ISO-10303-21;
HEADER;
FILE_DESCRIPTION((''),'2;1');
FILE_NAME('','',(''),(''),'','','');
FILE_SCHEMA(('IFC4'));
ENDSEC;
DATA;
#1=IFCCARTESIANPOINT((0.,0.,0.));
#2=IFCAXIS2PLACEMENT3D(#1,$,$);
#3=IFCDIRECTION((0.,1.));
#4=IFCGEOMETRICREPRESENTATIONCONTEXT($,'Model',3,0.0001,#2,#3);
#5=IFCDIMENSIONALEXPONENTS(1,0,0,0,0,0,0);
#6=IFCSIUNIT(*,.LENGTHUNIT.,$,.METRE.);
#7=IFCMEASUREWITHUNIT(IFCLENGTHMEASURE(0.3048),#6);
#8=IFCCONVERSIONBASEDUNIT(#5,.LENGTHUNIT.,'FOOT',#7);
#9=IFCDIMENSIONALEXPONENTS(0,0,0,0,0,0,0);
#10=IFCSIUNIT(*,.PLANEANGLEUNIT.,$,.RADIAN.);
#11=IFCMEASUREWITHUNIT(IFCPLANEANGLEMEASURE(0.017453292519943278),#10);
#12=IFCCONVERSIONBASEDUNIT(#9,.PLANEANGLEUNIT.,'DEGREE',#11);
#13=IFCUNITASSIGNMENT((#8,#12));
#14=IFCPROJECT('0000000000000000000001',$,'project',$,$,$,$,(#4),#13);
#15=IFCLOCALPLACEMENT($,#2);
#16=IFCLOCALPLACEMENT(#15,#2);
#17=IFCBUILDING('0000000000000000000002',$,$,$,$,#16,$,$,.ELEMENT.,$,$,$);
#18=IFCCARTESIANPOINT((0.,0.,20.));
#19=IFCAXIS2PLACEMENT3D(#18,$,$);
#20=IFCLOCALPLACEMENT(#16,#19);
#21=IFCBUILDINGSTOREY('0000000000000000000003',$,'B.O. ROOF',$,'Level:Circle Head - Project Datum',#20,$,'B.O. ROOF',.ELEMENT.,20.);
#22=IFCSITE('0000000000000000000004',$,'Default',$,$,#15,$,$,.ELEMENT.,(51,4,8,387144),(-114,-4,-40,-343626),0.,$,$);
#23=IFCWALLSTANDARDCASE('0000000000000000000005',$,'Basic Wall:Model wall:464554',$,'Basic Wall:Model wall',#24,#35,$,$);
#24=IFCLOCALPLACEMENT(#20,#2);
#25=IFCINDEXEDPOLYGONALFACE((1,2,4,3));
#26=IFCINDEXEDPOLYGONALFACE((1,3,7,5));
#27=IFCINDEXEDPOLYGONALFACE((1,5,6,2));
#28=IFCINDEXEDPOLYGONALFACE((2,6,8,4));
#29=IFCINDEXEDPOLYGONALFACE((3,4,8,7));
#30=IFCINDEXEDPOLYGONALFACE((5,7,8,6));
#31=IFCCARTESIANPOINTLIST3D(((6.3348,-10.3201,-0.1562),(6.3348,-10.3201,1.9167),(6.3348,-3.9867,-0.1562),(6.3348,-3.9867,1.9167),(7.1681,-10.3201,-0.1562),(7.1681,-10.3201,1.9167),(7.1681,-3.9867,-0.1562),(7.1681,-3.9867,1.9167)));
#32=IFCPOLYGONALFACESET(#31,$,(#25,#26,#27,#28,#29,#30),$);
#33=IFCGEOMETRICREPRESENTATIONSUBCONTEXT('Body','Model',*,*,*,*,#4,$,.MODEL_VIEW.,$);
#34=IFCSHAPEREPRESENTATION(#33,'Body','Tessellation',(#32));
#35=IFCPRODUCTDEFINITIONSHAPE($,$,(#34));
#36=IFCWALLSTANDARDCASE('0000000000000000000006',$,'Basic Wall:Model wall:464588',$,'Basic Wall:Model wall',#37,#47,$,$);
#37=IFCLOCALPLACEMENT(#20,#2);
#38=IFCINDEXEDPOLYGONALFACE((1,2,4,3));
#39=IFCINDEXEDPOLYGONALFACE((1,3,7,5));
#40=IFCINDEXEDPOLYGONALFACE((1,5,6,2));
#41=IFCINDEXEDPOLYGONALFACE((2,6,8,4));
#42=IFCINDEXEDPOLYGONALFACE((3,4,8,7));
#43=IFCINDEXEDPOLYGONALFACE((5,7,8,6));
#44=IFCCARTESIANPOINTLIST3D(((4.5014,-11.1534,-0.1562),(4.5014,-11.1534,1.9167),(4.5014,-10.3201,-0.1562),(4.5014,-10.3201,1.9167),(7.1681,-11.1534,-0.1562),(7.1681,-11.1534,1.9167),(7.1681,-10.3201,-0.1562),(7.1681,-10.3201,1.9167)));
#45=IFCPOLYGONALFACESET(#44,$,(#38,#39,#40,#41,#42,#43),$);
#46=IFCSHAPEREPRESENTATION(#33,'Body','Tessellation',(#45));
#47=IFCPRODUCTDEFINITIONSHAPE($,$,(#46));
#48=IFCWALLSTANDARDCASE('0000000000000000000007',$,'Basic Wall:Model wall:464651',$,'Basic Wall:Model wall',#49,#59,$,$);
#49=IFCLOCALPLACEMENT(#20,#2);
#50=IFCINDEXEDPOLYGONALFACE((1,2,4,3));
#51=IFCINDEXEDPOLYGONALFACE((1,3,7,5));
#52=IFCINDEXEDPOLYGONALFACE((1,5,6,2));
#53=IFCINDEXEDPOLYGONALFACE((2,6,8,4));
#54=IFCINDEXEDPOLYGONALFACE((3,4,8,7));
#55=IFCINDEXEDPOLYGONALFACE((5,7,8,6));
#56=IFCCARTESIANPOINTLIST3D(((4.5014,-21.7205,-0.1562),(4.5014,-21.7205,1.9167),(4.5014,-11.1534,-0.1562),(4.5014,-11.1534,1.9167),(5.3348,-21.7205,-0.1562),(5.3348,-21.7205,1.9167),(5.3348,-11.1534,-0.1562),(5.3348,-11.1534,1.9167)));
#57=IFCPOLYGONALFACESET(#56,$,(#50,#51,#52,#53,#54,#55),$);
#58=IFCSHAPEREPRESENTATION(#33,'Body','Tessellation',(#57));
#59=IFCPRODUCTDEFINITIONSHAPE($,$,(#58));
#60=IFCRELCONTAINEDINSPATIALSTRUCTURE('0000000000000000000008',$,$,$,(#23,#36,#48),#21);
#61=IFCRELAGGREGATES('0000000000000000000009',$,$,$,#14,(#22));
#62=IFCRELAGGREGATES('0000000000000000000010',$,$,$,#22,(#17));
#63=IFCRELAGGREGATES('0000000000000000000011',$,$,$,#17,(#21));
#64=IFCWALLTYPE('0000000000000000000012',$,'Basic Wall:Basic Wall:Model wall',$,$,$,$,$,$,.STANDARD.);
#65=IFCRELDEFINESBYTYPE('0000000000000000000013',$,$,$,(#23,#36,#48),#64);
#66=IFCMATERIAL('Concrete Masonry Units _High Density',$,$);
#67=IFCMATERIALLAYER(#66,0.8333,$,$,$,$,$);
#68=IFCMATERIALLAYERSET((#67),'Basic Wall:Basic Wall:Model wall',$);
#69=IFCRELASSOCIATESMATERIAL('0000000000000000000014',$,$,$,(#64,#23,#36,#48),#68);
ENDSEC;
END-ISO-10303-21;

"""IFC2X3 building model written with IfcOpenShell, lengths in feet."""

from ifc_helpers import new_model, entity, si_unit, converted_unit, direction, frame, frame_2d, origin, place, context, subcontext, project, spatial, rectangle, extrude, material, layer, layer_set, layer_usage, type_object, element, save


model = new_model("IFC2X3")

# Units and contexts
model_context = context("Model", 3, precision=0.0001, world=origin(), true_north=direction((0.0, 1.0)))
body_context = subcontext(model_context, "Body", "Model", "MODEL_VIEW")
ifc_project = project(units=[converted_unit("LENGTHUNIT", "FOOT", entity("IfcLengthMeasure", 0.3048), si_unit("LENGTHUNIT", "METRE"), dimensions=[1, 0, 0, 0, 0, 0, 0]), converted_unit("PLANEANGLEUNIT", "DEGREE", entity("IfcPlaneAngleMeasure", 0.017453292519943278), si_unit("PLANEANGLEUNIT", "RADIAN"), dimensions=[0, 0, 0, 0, 0, 0, 0])], contexts=[model_context])

# Site, building, storey
site_placement = place(None, origin())
site = spatial("IfcSite", under=ifc_project, at=site_placement, Name="Default", CompositionType="ELEMENT", RefLatitude=(51, 4, 8, 387144), RefLongitude=(-114, -4, -40, -343626), RefElevation=0.0)
building_placement = place(site_placement, origin())
building = spatial("IfcBuilding", under=site, at=building_placement, CompositionType="ELEMENT")
storey_placement = place(building_placement, frame((0.0, 0.0, 20.0)))
storey = spatial("IfcBuildingStorey", under=building, at=storey_placement, Name="B.O. ROOF", ObjectType="Level:Circle Head - Project Datum", LongName="B.O. ROOF", CompositionType="ELEMENT", Elevation=20.0)

# Walls
ifc_material_1 = material(Name="Concrete Masonry Units _High Density")
ifc_layer = layer(ifc_material_1, 0.8333)
ifc_layer_set = layer_set([ifc_layer], Name="Basic Wall:Basic Wall:Model wall")
wall_type = type_object("IfcWallType", Name="Basic Wall:Basic Wall:Model wall", PredefinedType="STANDARD", material=ifc_layer_set)
ifc_layer_usage_1 = layer_usage(ifc_layer_set, "AXIS2", "NEGATIVE", 0.4167)
wall_1_placement = place(storey_placement, frame((6.7514, -3.9867, -0.1562), z_axis=(0.0, 0.0, 1.0), x_axis=(0.0, -1.0, 0.0)))
element("IfcWallStandardCase", 1, at=wall_1_placement, inside=storey, type_object=wall_type, material=ifc_layer_usage_1, Name="Basic Wall:Model wall:464554", ObjectType="Basic Wall:Model wall", context=body_context, shape_type="SweptSolid", body=[
    extrude(rectangle(XDim=6.3333, YDim=0.8333, at=frame_2d((3.1667, 0.0), x_axis=(-1.0, 0.0))), origin(), (0.0, 0.0, 1.0), 2.0728),
])
ifc_layer_usage_2 = layer_usage(ifc_layer_set, "AXIS2", "NEGATIVE", 0.4167)
wall_2_placement = place(storey_placement, frame((7.1681, -10.7367, -0.1562), z_axis=(0.0, 0.0, 1.0), x_axis=(-1.0, 0.0, 0.0)))
element("IfcWallStandardCase", 2, at=wall_2_placement, inside=storey, type_object=wall_type, material=ifc_layer_usage_2, Name="Basic Wall:Model wall:464588", ObjectType="Basic Wall:Model wall", context=body_context, shape_type="SweptSolid", body=[
    extrude(rectangle(XDim=2.6667, YDim=0.8333, at=frame_2d((1.3333, 0.0), x_axis=(-1.0, 0.0))), origin(), (0.0, 0.0, 1.0), 2.0728),
])
ifc_layer_usage_3 = layer_usage(ifc_layer_set, "AXIS2", "NEGATIVE", 0.4167)
wall_3_placement = place(storey_placement, frame((4.9181, -11.1534, -0.1562), z_axis=(0.0, 0.0, 1.0), x_axis=(0.0, -1.0, 0.0)))
element("IfcWallStandardCase", 3, at=wall_3_placement, inside=storey, type_object=wall_type, material=ifc_layer_usage_3, Name="Basic Wall:Model wall:464651", ObjectType="Basic Wall:Model wall", context=body_context, shape_type="SweptSolid", body=[
    extrude(rectangle(XDim=10.5671, YDim=0.8333, at=frame_2d((5.2835, 0.0), x_axis=(-1.0, 0.0))), origin(), (0.0, 0.0, 1.0), 2.0728),
])

save(model, "model.ifc")
